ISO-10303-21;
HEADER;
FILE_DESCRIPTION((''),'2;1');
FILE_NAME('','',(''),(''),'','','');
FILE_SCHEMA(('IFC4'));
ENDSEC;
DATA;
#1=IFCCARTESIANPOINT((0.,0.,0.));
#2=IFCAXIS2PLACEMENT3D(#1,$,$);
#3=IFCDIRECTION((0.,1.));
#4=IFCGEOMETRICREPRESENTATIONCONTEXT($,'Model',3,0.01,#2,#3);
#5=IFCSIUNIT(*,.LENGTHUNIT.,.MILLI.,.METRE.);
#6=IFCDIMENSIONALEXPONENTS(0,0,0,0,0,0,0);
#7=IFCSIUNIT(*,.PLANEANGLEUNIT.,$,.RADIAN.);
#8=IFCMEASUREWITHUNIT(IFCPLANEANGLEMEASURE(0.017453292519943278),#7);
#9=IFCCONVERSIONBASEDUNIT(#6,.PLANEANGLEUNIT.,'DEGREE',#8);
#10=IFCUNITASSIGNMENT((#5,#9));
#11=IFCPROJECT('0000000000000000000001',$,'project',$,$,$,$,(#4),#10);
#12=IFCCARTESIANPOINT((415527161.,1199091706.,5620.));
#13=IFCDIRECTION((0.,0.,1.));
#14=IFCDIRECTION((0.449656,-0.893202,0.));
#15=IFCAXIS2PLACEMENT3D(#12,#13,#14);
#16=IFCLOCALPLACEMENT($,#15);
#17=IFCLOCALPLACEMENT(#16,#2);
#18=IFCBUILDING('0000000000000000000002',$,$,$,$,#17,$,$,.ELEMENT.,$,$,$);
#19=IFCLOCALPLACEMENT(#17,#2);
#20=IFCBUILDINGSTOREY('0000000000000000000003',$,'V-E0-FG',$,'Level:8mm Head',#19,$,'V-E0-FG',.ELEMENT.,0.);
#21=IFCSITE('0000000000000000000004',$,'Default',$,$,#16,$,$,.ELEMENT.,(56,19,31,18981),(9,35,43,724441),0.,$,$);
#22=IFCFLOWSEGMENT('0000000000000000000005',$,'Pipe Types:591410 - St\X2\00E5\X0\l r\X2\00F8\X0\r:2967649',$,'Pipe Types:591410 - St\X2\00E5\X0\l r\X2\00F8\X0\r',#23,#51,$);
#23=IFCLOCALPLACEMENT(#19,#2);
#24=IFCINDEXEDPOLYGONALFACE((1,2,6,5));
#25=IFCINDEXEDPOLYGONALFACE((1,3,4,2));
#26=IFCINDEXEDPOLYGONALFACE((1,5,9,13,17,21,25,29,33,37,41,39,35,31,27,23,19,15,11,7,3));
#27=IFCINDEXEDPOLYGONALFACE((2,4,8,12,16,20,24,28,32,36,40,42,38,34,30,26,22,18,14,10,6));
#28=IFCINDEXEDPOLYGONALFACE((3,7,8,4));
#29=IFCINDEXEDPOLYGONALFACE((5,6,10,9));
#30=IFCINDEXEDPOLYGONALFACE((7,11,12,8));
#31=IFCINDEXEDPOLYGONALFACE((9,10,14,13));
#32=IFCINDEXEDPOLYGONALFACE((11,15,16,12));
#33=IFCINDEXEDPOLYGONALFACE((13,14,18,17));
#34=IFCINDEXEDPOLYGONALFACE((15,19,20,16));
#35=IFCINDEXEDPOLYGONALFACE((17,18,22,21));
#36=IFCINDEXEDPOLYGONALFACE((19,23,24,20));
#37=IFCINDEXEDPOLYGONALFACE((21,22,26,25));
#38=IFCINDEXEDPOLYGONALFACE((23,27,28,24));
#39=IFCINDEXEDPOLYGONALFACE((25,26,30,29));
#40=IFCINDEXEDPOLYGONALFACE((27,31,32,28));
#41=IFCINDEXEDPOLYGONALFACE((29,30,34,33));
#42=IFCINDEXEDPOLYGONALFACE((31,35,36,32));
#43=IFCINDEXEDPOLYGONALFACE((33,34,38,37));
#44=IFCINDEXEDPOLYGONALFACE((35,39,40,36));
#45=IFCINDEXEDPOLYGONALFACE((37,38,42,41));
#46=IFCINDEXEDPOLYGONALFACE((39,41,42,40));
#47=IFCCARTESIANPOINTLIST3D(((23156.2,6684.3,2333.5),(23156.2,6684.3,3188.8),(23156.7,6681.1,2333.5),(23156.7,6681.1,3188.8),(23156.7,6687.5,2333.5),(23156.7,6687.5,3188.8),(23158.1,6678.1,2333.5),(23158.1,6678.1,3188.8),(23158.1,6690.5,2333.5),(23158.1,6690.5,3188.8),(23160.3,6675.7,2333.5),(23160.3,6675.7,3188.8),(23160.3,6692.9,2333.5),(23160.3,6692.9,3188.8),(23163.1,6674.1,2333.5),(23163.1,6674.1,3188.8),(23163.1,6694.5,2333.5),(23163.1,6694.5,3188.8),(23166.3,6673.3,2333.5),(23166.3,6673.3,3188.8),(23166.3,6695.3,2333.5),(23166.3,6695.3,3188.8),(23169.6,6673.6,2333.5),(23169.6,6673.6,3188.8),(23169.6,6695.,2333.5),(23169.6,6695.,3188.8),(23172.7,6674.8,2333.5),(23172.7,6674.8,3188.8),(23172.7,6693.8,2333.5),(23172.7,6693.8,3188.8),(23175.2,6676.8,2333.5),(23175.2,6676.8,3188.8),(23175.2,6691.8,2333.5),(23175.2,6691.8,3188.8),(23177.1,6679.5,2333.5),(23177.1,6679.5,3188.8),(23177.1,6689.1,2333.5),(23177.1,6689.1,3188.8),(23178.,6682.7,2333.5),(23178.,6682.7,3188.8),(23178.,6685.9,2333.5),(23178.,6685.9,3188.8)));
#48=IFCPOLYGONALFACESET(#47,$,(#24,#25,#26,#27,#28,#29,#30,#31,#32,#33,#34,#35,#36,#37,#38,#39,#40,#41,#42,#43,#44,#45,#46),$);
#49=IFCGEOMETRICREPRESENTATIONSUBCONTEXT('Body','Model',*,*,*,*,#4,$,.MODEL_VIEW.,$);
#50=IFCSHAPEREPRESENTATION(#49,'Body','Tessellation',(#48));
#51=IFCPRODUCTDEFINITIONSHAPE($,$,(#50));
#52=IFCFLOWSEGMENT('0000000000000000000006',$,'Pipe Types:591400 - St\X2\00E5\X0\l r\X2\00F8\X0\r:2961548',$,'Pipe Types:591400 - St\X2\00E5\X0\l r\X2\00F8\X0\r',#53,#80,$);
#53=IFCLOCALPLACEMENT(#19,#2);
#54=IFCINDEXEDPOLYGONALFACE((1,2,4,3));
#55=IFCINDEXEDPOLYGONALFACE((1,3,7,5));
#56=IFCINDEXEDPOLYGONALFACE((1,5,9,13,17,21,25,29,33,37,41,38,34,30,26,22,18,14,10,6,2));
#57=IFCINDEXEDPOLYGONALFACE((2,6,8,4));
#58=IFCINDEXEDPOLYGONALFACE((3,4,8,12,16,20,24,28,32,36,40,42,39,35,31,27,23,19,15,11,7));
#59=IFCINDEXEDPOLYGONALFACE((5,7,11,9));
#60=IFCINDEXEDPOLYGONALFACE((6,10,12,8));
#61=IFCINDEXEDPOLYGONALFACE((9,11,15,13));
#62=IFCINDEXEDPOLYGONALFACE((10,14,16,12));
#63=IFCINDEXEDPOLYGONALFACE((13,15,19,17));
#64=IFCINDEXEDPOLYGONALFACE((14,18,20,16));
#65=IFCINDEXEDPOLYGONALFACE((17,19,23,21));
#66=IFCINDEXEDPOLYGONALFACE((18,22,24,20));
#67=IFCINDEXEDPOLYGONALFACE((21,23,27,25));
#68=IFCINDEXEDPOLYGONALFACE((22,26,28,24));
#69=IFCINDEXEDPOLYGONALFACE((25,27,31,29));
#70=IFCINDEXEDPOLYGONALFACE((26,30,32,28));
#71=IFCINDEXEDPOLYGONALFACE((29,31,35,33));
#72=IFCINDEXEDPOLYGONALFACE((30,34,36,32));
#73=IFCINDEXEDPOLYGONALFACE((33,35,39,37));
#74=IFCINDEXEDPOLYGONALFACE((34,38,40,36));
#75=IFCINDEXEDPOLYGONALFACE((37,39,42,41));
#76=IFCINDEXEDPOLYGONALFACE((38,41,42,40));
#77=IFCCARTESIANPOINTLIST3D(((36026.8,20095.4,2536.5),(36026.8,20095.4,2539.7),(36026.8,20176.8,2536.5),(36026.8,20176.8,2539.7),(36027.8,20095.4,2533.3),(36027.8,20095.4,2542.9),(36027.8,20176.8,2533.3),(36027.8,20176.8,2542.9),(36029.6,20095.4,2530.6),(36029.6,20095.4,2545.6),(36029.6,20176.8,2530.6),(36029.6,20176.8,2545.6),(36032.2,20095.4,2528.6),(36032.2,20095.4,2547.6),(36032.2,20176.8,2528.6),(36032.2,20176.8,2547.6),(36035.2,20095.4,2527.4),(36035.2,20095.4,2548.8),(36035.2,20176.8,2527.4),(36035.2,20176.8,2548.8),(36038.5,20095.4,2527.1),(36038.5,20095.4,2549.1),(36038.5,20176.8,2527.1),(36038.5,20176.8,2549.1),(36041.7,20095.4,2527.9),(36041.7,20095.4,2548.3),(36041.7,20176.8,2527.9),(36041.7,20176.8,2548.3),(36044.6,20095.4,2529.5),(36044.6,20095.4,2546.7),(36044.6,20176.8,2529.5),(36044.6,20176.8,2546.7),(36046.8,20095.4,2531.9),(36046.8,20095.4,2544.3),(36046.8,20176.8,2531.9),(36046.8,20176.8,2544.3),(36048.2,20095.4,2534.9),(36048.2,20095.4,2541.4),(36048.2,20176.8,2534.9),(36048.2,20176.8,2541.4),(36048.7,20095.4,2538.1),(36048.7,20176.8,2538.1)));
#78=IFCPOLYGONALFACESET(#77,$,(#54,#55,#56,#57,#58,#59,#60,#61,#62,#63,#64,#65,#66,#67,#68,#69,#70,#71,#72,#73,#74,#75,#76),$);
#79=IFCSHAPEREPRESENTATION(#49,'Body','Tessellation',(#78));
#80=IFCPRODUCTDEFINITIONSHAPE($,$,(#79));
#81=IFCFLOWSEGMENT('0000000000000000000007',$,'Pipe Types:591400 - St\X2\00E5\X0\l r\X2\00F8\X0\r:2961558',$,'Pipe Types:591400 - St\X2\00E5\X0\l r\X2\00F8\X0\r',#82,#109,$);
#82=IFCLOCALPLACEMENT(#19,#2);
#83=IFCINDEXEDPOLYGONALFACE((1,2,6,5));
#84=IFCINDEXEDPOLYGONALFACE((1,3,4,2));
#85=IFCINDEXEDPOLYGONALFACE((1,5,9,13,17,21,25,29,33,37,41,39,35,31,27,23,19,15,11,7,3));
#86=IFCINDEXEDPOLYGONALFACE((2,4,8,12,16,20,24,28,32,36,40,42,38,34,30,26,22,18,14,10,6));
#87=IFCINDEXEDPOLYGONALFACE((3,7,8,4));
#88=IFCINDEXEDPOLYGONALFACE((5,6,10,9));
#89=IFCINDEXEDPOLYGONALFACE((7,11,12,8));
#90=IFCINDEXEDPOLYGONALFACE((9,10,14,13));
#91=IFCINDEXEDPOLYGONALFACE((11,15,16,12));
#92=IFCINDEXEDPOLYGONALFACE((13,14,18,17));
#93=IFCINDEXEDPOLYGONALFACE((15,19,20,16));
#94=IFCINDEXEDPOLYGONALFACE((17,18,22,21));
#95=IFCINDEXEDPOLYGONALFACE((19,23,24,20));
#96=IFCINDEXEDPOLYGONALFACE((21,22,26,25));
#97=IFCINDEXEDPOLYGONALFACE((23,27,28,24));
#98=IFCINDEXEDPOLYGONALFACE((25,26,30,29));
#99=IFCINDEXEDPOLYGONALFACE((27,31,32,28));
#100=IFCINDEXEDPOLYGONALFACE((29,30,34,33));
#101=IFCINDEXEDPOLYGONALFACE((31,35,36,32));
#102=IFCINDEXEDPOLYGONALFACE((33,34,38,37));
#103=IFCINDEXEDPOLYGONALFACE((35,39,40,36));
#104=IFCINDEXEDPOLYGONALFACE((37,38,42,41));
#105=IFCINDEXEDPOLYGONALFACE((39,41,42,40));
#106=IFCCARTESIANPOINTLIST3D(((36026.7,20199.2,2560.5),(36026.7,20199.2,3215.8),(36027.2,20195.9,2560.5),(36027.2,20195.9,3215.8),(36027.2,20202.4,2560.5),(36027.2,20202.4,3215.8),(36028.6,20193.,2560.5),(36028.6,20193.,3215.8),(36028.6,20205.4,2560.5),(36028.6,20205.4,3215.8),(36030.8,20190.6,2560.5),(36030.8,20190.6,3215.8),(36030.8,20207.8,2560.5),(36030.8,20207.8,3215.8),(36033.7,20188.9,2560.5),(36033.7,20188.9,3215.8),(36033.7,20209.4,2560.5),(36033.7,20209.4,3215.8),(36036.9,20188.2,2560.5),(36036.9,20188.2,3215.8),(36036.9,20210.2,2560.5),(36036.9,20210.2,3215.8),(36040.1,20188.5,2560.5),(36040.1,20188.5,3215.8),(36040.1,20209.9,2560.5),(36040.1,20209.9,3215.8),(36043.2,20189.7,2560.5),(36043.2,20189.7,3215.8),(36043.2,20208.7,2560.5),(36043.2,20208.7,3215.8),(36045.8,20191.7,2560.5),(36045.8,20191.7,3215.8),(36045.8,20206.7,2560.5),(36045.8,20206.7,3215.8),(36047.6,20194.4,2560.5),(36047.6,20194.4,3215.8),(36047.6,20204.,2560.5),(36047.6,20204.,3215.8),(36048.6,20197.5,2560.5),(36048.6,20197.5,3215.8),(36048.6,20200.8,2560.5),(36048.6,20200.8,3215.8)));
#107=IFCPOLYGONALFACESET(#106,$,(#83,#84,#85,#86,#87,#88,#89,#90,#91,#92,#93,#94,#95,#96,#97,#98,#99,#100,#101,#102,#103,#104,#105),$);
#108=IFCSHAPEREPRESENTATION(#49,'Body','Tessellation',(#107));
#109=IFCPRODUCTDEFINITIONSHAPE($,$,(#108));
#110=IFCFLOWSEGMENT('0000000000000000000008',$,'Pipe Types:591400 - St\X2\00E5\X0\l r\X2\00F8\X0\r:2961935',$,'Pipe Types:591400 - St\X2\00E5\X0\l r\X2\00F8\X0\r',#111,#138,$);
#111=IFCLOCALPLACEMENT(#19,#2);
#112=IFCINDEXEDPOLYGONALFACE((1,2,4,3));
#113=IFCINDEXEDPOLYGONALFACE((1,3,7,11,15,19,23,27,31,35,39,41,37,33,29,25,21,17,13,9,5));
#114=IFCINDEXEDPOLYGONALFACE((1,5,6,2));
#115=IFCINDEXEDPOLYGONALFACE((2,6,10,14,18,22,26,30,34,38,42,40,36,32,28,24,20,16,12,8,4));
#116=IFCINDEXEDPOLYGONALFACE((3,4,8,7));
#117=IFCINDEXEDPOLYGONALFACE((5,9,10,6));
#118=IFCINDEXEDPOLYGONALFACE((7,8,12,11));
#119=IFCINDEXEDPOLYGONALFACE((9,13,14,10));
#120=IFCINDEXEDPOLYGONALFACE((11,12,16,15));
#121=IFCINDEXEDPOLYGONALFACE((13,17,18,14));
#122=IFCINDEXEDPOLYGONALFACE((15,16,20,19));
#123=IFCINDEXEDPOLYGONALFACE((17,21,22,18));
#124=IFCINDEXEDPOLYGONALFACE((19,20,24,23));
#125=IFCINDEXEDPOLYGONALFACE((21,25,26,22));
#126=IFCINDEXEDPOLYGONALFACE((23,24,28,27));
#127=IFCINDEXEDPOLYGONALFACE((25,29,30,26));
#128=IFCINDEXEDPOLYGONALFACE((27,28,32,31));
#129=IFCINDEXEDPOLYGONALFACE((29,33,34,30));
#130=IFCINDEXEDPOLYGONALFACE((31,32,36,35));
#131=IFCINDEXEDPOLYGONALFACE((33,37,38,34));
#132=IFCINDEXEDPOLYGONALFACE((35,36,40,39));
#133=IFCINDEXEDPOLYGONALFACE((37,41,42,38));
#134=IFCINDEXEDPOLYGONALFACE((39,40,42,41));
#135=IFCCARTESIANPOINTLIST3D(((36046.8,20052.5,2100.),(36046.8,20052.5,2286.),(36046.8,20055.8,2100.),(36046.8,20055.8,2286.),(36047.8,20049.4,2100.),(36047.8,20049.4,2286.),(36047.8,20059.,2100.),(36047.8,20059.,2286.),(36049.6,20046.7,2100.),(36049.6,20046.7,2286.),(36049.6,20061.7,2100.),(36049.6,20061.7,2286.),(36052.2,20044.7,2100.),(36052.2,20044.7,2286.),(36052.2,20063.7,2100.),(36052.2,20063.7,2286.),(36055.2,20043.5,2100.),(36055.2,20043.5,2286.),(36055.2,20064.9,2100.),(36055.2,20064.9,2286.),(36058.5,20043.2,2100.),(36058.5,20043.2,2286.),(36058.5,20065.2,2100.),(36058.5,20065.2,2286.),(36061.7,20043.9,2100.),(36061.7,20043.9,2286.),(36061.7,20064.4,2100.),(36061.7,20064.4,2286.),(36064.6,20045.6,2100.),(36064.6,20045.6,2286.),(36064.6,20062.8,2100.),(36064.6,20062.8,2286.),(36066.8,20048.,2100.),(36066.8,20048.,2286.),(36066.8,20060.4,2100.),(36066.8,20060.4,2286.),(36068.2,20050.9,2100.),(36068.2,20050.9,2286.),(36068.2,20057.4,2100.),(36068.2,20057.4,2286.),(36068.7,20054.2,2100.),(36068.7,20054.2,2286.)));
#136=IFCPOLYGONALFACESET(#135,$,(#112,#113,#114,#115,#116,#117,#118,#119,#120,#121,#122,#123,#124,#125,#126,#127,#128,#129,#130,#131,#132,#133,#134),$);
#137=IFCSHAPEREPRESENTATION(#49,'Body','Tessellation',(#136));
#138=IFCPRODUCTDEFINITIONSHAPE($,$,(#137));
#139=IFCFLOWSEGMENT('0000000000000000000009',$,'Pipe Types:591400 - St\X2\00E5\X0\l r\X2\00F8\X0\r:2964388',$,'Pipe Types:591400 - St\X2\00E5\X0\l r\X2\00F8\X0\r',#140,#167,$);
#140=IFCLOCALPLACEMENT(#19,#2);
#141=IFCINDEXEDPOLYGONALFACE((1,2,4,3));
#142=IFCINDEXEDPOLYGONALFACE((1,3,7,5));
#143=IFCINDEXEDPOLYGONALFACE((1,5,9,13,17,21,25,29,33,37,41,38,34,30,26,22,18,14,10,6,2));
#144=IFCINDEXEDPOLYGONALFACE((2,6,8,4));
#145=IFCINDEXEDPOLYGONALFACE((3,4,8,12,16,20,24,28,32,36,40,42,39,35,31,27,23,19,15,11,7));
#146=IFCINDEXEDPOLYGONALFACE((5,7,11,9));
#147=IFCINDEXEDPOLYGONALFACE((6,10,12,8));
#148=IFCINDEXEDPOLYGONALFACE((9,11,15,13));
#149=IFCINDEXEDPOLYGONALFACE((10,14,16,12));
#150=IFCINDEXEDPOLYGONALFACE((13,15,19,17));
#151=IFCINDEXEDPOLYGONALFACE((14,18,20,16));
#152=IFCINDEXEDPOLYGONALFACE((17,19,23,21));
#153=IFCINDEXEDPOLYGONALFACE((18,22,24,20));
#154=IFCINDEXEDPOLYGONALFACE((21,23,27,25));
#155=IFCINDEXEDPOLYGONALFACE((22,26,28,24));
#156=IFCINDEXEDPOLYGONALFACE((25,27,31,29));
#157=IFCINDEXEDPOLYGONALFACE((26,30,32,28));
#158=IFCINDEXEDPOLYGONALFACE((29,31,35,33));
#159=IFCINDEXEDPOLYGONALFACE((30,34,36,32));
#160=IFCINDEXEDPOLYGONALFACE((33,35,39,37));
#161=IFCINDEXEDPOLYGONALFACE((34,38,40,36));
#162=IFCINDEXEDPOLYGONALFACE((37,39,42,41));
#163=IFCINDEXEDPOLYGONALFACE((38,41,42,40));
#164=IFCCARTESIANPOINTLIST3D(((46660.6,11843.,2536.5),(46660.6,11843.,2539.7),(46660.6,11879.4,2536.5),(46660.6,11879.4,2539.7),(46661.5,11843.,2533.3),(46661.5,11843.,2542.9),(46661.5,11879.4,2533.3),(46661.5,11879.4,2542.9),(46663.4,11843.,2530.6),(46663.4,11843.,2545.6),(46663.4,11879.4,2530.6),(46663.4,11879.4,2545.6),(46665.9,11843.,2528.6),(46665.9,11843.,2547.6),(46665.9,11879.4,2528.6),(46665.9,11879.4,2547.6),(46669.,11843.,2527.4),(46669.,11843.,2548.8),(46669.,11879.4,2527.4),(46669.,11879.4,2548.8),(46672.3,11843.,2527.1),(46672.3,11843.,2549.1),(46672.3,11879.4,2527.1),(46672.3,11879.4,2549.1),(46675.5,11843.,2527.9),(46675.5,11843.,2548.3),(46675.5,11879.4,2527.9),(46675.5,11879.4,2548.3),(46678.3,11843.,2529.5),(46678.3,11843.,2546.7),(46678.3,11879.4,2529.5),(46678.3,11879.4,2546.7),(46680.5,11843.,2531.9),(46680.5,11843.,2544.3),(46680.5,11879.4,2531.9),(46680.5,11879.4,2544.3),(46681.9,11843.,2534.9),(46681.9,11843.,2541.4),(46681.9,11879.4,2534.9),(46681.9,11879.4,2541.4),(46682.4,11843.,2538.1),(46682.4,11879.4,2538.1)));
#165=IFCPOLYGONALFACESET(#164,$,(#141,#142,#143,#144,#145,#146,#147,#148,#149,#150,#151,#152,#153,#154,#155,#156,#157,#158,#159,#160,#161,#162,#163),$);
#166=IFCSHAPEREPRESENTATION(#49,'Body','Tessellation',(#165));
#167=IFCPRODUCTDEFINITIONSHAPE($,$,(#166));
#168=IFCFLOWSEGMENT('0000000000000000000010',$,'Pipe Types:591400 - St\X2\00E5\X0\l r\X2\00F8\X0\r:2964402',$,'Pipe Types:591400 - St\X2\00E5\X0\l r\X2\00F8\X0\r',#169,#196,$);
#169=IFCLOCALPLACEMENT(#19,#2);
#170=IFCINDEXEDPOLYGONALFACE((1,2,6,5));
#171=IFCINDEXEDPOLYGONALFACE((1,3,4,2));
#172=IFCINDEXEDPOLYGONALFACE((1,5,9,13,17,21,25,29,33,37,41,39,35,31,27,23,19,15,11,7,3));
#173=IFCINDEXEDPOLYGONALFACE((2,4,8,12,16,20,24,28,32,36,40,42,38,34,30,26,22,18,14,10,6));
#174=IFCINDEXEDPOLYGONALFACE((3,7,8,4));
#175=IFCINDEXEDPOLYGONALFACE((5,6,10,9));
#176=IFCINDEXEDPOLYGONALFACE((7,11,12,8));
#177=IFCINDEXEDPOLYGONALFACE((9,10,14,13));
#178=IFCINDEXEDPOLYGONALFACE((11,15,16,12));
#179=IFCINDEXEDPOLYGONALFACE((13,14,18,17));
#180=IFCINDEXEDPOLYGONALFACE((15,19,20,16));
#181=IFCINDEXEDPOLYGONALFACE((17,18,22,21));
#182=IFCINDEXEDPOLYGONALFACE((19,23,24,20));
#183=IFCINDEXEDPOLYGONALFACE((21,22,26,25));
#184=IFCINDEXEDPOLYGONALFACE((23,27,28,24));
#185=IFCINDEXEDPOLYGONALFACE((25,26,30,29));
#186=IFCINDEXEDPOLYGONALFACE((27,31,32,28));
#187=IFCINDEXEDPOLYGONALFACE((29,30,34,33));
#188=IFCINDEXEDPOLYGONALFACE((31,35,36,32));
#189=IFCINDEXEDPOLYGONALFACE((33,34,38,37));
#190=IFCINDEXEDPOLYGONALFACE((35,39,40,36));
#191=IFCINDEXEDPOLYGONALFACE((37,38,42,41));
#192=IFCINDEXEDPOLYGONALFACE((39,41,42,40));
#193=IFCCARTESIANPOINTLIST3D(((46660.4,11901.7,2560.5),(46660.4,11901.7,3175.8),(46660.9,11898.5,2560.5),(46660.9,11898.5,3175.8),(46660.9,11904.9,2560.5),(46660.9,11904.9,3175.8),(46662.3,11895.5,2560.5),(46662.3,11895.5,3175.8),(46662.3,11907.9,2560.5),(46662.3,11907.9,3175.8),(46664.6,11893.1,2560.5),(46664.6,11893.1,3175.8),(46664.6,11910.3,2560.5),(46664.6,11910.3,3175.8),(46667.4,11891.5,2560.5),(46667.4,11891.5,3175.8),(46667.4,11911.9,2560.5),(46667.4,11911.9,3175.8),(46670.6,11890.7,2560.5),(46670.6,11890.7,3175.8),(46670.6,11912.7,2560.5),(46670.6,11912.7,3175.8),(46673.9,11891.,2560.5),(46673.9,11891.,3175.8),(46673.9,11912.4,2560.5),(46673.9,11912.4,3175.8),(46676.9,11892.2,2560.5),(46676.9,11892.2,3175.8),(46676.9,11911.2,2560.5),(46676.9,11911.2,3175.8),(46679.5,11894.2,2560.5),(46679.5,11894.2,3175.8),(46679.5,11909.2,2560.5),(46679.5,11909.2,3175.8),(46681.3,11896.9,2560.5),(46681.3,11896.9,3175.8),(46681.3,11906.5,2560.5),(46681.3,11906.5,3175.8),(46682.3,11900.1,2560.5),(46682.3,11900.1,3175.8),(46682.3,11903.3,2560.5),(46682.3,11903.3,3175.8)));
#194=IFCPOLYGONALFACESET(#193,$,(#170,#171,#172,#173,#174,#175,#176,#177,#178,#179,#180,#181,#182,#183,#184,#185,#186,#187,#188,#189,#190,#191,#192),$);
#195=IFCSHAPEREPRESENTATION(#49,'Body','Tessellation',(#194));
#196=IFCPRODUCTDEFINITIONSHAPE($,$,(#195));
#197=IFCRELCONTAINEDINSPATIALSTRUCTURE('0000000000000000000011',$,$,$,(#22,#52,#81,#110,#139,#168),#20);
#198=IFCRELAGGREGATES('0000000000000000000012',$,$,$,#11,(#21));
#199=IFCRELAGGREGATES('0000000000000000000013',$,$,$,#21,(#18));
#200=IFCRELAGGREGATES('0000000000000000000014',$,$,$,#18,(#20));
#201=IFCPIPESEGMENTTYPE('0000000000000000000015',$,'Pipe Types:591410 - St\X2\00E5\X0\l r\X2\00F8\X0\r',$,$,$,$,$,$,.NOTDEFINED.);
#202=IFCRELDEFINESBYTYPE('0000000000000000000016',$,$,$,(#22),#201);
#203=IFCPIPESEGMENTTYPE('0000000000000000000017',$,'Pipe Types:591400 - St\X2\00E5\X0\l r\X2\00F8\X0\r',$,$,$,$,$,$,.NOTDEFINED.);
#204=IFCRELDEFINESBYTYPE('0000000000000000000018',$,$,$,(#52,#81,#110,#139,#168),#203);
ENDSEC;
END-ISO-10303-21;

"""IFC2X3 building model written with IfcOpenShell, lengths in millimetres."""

from ifc_helpers import new_model, entity, si_unit, converted_unit, direction, frame, frame_2d, origin, origin_2d_with_axis, place, context, subcontext, project, spatial, circle, extrude, type_object, element, save


model = new_model("IFC2X3")

# Units and contexts
model_context = context("Model", 3, precision=0.01, world=origin(), true_north=direction((0.0, 1.0)))
body_context = subcontext(model_context, "Body", "Model", "MODEL_VIEW")
ifc_project = project(units=[si_unit("LENGTHUNIT", "METRE", prefix="MILLI"), converted_unit("PLANEANGLEUNIT", "DEGREE", entity("IfcPlaneAngleMeasure", 0.017453292519943278), si_unit("PLANEANGLEUNIT", "RADIAN"), dimensions=[0, 0, 0, 0, 0, 0, 0])], contexts=[model_context])

# Site, building, storey
site_placement = place(None, frame((415527161.0, 1199091706.0, 5620.0), z_axis=(0.0, 0.0, 1.0), x_axis=(0.449656, -0.893202, 0.0)))
site = spatial("IfcSite", under=ifc_project, at=site_placement, Name="Default", CompositionType="ELEMENT", RefLatitude=(56, 19, 31, 18981), RefLongitude=(9, 35, 43, 724441), RefElevation=0.0)
building_placement = place(site_placement, origin())
building = spatial("IfcBuilding", under=site, at=building_placement, CompositionType="ELEMENT")
storey_placement = place(building_placement, origin())
storey = spatial("IfcBuildingStorey", under=building, at=storey_placement, Name="V-E0-FG", ObjectType="Level:8mm Head", LongName="V-E0-FG", CompositionType="ELEMENT", Elevation=0.0)

# Flow segments
pipe_segment_type_1 = type_object("IfcPipeSegmentType", Name="Pipe Types:591410 - Stål rør", PredefinedType="NOTDEFINED")
flow_segment_1_placement = place(storey_placement, origin())
element("IfcFlowSegment", 1, at=flow_segment_1_placement, inside=storey, type_object=pipe_segment_type_1, Name="Pipe Types:591410 - Stål rør:2967649", ObjectType="Pipe Types:591410 - Stål rør", context=body_context, shape_type="SweptSolid", body=[
    extrude(circle(Radius=11.0, at=origin_2d_with_axis()), frame((23167.2, 6684.3, 2333.5), z_axis=(0.0, 0.0, 1.0), x_axis=(-1.0, 0.0, 0.0)), (0.0, 0.0, 1.0), 855.3),
])
pipe_segment_type_2 = type_object("IfcPipeSegmentType", Name="Pipe Types:591400 - Stål rør", PredefinedType="NOTDEFINED")
flow_segment_2_placement = place(storey_placement, origin())
element("IfcFlowSegment", 2, at=flow_segment_2_placement, inside=storey, type_object=pipe_segment_type_2, Name="Pipe Types:591400 - Stål rør:2961548", ObjectType="Pipe Types:591400 - Stål rør", context=body_context, shape_type="SweptSolid", body=[
    extrude(circle(Radius=11.0, at=frame_2d((0.0, 0.0), x_axis=(1.0, 0.0))), frame((36037.7, 20095.4, 2538.1), z_axis=(0.0, 1.0, 0.0), x_axis=(1.0, 0.0, 0.0)), (0.0, 0.0, 1.0), 81.4),
])
flow_segment_3_placement = place(storey_placement, origin())
element("IfcFlowSegment", 3, at=flow_segment_3_placement, inside=storey, type_object=pipe_segment_type_2, Name="Pipe Types:591400 - Stål rør:2961558", ObjectType="Pipe Types:591400 - Stål rør", context=body_context, shape_type="SweptSolid", body=[
    extrude(circle(Radius=11.0, at=origin_2d_with_axis()), frame((36037.7, 20199.2, 2560.5), z_axis=(0.0, 0.0, 1.0), x_axis=(-1.0, 0.0, 0.0)), (0.0, 0.0, 1.0), 655.3),
])
flow_segment_4_placement = place(storey_placement, origin())
element("IfcFlowSegment", 4, at=flow_segment_4_placement, inside=storey, type_object=pipe_segment_type_2, Name="Pipe Types:591400 - Stål rør:2961935", ObjectType="Pipe Types:591400 - Stål rør", context=body_context, shape_type="SweptSolid", body=[
    extrude(circle(Radius=11.0, at=origin_2d_with_axis()), frame((36057.7, 20054.2, 2100.0)), (0.0, 0.0, 1.0), 186.0),
])
flow_segment_5_placement = place(storey_placement, origin())
element("IfcFlowSegment", 5, at=flow_segment_5_placement, inside=storey, type_object=pipe_segment_type_2, Name="Pipe Types:591400 - Stål rør:2964388", ObjectType="Pipe Types:591400 - Stål rør", context=body_context, shape_type="SweptSolid", body=[
    extrude(circle(Radius=11.0, at=frame_2d((0.0, 0.0), x_axis=(1.0, 0.0))), frame((46671.4, 11843.0, 2538.1), z_axis=(0.0, 1.0, 0.0), x_axis=(1.0, 0.0, 0.0)), (0.0, 0.0, 1.0), 36.4),
])
flow_segment_6_placement = place(storey_placement, origin())
element("IfcFlowSegment", 6, at=flow_segment_6_placement, inside=storey, type_object=pipe_segment_type_2, Name="Pipe Types:591400 - Stål rør:2964402", ObjectType="Pipe Types:591400 - Stål rør", context=body_context, shape_type="SweptSolid", body=[
    extrude(circle(Radius=11.0, at=frame_2d((0.0, 0.0), x_axis=(1.0, 0.0))), frame((46671.4, 11901.7, 2560.5), z_axis=(0.0, 0.0, 1.0), x_axis=(-1.0, 0.0, 0.0)), (0.0, 0.0, 1.0), 615.3),
])

save(model, "model.ifc")
